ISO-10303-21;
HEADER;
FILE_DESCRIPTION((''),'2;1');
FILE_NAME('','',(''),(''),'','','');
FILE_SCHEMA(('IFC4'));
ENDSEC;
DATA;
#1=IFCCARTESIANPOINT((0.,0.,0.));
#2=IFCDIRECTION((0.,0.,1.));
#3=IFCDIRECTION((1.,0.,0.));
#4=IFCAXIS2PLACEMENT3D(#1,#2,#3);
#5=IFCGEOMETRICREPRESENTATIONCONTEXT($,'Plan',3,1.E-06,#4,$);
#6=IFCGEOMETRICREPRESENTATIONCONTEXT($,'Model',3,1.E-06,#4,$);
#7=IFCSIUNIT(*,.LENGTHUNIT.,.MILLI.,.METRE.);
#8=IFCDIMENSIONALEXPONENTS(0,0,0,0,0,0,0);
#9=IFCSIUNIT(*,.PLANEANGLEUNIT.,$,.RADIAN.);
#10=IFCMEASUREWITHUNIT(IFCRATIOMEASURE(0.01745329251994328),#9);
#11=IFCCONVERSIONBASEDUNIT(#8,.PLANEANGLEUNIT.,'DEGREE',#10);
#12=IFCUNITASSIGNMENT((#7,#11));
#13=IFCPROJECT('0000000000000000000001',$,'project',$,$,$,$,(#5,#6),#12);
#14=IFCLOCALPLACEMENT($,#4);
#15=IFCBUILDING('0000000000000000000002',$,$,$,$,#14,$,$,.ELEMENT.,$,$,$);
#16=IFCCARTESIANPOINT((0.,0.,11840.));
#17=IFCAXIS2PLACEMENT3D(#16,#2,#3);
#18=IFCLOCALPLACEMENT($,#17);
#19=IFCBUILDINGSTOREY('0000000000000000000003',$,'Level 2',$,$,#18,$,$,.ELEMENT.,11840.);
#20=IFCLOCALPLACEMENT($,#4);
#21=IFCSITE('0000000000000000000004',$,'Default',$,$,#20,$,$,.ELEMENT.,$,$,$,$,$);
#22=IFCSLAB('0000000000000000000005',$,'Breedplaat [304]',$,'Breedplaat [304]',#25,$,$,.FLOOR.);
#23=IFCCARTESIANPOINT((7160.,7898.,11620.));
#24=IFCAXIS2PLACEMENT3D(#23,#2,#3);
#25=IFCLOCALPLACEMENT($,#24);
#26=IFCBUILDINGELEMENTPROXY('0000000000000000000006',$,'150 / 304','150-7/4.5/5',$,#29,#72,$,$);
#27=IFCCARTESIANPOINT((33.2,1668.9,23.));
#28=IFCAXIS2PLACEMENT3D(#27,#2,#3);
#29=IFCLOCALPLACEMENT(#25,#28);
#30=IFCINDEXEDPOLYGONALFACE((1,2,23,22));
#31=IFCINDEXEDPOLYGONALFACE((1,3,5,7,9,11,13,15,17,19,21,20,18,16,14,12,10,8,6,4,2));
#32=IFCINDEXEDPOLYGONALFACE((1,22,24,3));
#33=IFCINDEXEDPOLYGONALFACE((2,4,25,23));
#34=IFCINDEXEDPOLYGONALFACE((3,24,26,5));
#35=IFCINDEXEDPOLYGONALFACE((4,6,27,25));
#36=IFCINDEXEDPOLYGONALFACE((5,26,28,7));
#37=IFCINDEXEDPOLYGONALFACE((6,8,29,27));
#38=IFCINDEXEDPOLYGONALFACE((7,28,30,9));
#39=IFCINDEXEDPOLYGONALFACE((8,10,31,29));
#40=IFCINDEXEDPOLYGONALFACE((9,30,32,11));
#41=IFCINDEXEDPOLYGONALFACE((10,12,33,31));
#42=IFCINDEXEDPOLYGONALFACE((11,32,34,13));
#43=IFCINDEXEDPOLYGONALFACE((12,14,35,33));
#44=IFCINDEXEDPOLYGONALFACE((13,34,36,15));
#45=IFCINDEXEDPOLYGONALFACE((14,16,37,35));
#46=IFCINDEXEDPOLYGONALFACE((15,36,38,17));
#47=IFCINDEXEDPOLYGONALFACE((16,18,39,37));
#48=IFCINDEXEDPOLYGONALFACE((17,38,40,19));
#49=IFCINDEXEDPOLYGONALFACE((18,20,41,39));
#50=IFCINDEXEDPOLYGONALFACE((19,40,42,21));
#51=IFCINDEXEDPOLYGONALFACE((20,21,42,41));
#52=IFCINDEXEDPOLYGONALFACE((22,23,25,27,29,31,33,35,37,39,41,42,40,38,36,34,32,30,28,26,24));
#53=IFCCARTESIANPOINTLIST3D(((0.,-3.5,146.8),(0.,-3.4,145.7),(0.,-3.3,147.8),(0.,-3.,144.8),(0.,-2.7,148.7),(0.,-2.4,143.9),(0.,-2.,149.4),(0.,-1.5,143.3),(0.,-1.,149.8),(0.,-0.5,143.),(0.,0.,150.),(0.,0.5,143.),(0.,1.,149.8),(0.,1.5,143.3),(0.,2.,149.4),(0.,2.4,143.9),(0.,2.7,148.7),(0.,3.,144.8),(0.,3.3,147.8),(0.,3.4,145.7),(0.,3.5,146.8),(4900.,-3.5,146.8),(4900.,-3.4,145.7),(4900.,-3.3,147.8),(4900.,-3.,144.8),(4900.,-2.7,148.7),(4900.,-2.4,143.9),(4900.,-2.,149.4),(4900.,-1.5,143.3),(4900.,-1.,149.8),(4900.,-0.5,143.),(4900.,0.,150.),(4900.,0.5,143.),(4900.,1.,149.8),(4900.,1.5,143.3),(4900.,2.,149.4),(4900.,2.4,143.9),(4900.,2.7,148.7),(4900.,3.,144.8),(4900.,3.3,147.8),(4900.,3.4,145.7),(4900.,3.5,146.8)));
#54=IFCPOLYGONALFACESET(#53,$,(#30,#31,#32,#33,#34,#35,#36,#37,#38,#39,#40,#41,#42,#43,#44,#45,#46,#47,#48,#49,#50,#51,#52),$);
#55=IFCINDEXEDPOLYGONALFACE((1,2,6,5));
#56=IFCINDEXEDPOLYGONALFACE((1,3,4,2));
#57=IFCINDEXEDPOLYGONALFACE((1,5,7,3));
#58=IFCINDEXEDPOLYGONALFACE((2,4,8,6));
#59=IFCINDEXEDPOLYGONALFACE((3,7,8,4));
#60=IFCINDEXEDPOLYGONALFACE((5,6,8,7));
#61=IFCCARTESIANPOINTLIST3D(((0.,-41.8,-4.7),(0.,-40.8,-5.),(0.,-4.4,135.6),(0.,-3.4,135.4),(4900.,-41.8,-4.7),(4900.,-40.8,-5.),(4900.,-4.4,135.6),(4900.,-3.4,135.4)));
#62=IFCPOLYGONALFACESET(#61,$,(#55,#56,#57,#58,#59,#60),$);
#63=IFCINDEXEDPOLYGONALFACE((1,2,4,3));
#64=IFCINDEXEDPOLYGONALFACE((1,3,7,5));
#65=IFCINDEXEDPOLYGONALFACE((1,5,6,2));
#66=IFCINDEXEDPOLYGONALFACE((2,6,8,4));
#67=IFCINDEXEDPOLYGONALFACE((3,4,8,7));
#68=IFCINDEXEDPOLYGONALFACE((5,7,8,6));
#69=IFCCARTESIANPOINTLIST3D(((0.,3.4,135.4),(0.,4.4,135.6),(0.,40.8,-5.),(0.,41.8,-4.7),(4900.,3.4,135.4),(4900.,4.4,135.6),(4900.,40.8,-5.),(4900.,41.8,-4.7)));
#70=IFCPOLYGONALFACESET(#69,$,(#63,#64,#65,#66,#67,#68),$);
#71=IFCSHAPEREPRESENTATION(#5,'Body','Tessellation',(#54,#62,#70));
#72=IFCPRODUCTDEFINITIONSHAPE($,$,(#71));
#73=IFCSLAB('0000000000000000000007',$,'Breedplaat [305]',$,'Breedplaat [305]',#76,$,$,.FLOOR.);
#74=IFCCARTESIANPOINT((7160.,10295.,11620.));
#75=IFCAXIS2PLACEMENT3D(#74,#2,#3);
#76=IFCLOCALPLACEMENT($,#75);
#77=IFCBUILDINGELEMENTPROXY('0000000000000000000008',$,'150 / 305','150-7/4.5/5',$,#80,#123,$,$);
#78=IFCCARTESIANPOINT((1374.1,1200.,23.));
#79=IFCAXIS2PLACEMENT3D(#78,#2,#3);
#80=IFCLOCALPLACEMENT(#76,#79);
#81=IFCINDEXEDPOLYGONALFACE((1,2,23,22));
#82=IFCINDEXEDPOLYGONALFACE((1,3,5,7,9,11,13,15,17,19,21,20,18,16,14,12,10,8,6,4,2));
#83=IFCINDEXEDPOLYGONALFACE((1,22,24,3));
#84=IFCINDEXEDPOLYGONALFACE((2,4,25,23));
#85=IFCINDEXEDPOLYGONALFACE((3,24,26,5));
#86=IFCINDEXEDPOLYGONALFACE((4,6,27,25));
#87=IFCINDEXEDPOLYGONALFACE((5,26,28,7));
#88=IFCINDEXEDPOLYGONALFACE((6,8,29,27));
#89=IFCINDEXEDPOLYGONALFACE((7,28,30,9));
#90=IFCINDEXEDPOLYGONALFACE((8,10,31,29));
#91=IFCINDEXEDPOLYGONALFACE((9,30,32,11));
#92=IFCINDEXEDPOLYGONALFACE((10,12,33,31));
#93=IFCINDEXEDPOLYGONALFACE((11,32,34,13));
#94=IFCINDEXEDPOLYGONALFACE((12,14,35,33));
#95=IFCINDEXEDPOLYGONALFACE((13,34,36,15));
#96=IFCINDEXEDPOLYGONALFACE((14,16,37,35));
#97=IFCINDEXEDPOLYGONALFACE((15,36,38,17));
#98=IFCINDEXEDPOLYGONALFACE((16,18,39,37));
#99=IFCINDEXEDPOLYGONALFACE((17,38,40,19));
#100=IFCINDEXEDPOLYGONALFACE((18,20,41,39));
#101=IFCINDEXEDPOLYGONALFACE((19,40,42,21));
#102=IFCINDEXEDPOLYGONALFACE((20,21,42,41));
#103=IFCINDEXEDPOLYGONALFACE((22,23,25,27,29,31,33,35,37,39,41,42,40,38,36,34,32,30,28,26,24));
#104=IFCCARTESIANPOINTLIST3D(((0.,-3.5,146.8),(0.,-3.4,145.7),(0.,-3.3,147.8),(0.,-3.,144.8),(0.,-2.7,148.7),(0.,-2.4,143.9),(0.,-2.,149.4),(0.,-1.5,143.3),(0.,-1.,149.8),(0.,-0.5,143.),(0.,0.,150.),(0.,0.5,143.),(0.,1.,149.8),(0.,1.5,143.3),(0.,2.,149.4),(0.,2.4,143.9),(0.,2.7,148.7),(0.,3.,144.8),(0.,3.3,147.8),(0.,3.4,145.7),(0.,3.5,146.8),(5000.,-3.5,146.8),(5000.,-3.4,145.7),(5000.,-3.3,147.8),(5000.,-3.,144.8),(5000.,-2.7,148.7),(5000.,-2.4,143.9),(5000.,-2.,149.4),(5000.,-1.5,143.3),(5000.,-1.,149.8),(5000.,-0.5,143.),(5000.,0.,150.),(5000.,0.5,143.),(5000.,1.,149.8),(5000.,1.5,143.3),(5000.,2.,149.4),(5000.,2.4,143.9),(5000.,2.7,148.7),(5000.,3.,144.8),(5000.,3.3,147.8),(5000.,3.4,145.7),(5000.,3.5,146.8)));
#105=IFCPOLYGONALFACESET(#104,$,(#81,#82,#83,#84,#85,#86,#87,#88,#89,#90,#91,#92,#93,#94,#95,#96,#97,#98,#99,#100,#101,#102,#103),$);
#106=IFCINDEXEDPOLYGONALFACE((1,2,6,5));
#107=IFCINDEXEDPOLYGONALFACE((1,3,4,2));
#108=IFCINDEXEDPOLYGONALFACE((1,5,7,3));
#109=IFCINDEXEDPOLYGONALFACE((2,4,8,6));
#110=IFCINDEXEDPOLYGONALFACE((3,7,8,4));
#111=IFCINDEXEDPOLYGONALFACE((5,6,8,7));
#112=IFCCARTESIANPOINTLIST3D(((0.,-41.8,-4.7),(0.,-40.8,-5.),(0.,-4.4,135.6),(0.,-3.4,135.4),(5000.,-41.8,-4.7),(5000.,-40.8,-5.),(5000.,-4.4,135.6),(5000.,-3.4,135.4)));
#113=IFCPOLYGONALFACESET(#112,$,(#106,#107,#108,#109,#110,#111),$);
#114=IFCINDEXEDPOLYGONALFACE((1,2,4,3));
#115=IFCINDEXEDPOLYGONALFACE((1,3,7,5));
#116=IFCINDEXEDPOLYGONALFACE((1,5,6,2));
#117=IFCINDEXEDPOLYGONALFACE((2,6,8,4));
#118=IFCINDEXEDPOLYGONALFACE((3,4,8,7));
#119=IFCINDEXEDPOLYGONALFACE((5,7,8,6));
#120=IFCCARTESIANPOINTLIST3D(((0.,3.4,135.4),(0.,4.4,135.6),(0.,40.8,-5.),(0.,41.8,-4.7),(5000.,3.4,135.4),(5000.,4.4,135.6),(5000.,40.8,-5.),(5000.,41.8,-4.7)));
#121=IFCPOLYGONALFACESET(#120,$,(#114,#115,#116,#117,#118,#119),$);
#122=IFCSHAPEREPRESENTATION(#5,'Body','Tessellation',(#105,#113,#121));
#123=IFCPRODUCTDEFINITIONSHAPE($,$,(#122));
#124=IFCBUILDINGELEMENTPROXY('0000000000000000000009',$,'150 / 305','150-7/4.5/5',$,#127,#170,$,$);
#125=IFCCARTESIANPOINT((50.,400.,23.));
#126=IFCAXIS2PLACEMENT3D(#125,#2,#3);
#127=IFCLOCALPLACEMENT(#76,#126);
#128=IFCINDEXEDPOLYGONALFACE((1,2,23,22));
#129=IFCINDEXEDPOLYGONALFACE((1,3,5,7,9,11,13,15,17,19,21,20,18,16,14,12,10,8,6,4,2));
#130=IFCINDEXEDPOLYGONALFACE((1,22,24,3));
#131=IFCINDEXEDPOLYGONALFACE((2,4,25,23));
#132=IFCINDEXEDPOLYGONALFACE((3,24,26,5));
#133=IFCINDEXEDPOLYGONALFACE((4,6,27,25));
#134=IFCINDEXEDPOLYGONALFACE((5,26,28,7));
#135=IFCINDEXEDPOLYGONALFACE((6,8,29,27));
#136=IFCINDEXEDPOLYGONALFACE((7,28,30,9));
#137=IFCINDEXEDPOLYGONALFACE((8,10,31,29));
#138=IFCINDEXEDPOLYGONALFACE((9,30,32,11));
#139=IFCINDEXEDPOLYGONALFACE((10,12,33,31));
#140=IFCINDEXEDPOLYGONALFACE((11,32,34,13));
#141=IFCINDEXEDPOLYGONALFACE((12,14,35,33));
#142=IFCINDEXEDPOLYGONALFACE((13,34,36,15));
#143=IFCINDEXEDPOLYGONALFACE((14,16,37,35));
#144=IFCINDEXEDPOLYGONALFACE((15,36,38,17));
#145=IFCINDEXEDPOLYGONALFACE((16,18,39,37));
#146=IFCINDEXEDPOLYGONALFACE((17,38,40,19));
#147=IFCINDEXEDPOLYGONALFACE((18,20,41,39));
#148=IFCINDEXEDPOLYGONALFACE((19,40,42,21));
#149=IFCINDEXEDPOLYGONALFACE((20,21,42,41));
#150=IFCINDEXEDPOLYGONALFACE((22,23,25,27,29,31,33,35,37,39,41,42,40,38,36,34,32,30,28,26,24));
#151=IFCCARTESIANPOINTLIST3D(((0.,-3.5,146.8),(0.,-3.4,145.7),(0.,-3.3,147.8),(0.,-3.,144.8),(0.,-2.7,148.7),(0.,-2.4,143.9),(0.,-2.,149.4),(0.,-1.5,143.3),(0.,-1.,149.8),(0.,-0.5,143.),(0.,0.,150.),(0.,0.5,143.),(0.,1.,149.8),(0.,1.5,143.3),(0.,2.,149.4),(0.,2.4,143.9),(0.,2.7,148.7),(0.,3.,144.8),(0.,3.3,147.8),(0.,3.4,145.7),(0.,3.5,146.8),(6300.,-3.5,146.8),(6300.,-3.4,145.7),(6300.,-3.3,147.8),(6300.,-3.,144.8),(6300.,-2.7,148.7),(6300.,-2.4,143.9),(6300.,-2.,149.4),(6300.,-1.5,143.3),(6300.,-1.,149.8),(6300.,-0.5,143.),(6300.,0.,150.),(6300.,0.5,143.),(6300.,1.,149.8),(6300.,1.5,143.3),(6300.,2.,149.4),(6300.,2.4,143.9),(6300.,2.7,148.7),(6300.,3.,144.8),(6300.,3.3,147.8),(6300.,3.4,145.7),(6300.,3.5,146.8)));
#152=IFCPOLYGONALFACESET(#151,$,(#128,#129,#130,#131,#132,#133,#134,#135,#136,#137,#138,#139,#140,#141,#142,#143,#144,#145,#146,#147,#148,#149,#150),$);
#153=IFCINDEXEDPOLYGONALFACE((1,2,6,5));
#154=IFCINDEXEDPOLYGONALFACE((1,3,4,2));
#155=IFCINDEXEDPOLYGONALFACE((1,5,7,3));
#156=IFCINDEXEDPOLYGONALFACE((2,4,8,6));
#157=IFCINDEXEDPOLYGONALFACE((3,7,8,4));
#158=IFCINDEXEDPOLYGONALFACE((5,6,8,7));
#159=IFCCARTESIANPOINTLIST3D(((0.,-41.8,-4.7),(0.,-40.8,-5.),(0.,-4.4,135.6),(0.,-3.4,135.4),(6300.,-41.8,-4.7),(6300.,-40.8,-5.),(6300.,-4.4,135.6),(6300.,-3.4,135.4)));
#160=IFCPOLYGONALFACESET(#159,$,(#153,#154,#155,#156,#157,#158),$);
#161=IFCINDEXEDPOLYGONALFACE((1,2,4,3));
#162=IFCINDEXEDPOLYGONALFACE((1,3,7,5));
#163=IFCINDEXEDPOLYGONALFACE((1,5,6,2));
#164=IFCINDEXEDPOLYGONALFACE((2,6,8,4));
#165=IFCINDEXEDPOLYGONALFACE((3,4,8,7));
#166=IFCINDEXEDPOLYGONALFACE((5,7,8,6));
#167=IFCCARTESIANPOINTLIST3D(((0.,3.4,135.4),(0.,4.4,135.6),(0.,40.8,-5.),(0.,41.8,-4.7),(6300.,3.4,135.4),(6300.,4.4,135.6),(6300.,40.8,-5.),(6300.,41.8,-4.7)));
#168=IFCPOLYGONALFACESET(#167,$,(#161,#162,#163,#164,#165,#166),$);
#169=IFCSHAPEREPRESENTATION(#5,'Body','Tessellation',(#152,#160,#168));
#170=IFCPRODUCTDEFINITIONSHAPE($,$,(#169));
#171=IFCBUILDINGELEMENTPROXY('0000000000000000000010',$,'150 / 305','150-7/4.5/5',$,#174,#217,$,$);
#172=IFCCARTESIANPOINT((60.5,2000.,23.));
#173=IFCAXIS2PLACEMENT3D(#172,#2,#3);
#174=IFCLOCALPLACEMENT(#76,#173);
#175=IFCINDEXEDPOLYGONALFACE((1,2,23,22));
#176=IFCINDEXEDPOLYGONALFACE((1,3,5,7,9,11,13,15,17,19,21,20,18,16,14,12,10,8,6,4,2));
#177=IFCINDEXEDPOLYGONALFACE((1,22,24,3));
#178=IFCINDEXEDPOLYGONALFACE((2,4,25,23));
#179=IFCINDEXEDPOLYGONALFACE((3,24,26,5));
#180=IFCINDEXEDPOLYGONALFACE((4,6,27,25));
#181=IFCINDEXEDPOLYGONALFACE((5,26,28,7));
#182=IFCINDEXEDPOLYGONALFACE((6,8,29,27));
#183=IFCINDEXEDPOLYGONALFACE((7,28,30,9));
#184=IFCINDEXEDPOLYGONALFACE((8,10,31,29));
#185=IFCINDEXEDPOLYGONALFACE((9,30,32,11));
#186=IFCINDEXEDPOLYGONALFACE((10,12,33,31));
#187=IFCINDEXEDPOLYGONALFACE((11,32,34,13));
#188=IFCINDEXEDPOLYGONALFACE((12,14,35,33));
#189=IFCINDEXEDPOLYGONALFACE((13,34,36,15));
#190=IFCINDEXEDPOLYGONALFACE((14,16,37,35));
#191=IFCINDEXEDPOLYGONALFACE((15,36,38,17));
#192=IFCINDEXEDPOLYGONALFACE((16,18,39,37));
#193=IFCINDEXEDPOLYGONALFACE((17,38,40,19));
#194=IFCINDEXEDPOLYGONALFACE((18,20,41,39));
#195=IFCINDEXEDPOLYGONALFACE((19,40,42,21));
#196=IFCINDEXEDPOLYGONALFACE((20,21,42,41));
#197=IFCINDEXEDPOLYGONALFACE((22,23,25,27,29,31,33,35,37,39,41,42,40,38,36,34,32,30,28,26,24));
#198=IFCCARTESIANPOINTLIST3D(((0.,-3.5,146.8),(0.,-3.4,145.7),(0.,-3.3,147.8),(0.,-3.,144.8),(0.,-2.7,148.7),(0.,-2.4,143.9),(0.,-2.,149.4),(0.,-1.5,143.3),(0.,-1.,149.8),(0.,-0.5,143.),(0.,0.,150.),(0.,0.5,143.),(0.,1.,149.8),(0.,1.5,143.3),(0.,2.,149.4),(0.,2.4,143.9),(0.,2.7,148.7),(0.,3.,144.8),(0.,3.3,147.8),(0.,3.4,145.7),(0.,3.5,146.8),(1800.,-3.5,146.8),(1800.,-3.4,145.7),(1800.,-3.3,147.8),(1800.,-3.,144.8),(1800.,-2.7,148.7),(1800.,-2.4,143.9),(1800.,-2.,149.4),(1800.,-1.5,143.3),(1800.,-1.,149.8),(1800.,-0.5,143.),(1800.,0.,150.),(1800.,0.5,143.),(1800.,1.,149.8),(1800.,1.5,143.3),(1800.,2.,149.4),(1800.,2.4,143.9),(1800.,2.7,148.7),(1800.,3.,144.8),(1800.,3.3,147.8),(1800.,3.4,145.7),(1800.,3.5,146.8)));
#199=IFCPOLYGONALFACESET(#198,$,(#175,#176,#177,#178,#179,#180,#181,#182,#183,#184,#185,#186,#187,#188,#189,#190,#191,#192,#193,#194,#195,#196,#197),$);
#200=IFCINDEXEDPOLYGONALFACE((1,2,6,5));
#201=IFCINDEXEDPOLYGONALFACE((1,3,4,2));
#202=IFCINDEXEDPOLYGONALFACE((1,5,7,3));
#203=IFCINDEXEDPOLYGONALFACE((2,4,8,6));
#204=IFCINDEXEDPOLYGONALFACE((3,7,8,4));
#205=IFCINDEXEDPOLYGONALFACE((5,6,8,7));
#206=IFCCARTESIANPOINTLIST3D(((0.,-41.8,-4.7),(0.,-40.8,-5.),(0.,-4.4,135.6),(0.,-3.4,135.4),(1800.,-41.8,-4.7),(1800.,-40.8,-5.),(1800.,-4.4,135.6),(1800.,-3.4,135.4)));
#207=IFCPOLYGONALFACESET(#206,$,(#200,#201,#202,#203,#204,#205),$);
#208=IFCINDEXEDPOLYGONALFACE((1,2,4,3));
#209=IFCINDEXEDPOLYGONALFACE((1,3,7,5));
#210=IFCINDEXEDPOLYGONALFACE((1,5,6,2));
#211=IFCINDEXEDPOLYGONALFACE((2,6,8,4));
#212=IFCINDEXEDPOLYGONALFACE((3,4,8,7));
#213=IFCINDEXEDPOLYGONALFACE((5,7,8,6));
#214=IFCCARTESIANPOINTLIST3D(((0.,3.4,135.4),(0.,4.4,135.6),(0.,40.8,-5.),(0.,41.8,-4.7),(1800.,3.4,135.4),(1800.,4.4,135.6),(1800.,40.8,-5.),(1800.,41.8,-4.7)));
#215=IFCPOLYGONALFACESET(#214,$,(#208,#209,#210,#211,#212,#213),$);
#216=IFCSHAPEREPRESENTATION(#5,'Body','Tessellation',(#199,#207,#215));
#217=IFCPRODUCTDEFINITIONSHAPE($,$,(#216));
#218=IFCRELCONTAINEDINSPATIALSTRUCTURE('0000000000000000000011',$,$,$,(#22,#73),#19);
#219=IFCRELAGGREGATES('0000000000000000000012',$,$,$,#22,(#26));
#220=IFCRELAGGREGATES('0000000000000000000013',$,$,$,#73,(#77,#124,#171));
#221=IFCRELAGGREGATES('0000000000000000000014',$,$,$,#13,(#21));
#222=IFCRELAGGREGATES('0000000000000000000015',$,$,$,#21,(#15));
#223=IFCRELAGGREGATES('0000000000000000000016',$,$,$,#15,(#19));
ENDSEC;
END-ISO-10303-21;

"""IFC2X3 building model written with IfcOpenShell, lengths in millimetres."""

from ifc_helpers import new_model, entity, si_unit, converted_unit, frame, origin_with_axes, origin_2d_with_axis, place, context, project, spatial, rectangle, circle, extrude, element, aggregate, save


model = new_model("IFC2X3")

# Units and contexts
plan_context = context("Plan", 3, precision=1e-06, world=origin_with_axes())
model_context = context("Model", 3, precision=1e-06, world=origin_with_axes())
ifc_project = project(units=[si_unit("LENGTHUNIT", "METRE", prefix="MILLI"), converted_unit("PLANEANGLEUNIT", "DEGREE", entity("IfcRatioMeasure", 0.01745329251994328), si_unit("PLANEANGLEUNIT", "RADIAN"), dimensions=[0, 0, 0, 0, 0, 0, 0])], contexts=[plan_context, model_context])

# Site, building, storey
site_placement = place(None, origin_with_axes())
site = spatial("IfcSite", under=ifc_project, at=site_placement, Name="Default", CompositionType="ELEMENT")
building_placement = place(None, origin_with_axes())
building = spatial("IfcBuilding", under=site, at=building_placement, CompositionType="ELEMENT")
storey_placement = place(None, frame((0.0, 0.0, 11840.0), z_axis=(0.0, 0.0, 1.0), x_axis=(1.0, 0.0, 0.0)))
storey = spatial("IfcBuildingStorey", under=building, at=storey_placement, Name="Level 2", CompositionType="ELEMENT", Elevation=11840.0)

# Slab, building element proxy
slab_1_placement = place(None, frame((7160.0, 7898.0, 11620.0), z_axis=(0.0, 0.0, 1.0), x_axis=(1.0, 0.0, 0.0)))
slab_1 = element("IfcSlab", 1, at=slab_1_placement, inside=storey, Name="Breedplaat [304]", ObjectType="Breedplaat [304]", PredefinedType="FLOOR")
proxy_1_placement = place(slab_1_placement, frame((33.2, 1668.9, 23.0), z_axis=(0.0, 0.0, 1.0), x_axis=(1.0, 0.0, 0.0)))
proxy_1 = element("IfcBuildingElementProxy", 2, at=proxy_1_placement, Name="150 / 304", Description="150-7/4.5/5", context=plan_context, shape_type="SweptSolid", body=[
    extrude(circle(Radius=3.5, at=origin_2d_with_axis()), frame((0.0, 0.0, 146.5), z_axis=(1.0, 0.0, 0.0), x_axis=(0.0, 0.0, 1.0)), (0.0, 0.0, 1.0), 4900.0),
    extrude(rectangle(XDim=145.2, YDim=1.0, at=origin_2d_with_axis()), frame((0.0, -22.6, 65.3), z_axis=(1.0, 0.0, 0.0), x_axis=(0.0, 0.257663, 0.966235)), (0.0, 0.0, 1.0), 4900.0),
    extrude(rectangle(XDim=145.2, YDim=1.0, at=origin_2d_with_axis()), frame((0.0, 22.6, 65.3), z_axis=(1.0, 0.0, 0.0), x_axis=(0.0, -0.257663, 0.966235)), (0.0, 0.0, 1.0), 4900.0),
])
aggregate(slab_1, [proxy_1])

# Slab, building element proxies
slab_2_placement = place(None, frame((7160.0, 10295.0, 11620.0), z_axis=(0.0, 0.0, 1.0), x_axis=(1.0, 0.0, 0.0)))
slab_2 = element("IfcSlab", 3, at=slab_2_placement, inside=storey, Name="Breedplaat [305]", ObjectType="Breedplaat [305]", PredefinedType="FLOOR")
proxy_2_placement = place(slab_2_placement, frame((1374.1, 1200.0, 23.0), z_axis=(0.0, 0.0, 1.0), x_axis=(1.0, 0.0, 0.0)))
proxy_2 = element("IfcBuildingElementProxy", 4, at=proxy_2_placement, Name="150 / 305", Description="150-7/4.5/5", context=plan_context, shape_type="SweptSolid", body=[
    extrude(circle(Radius=3.5, at=origin_2d_with_axis()), frame((0.0, 0.0, 146.5), z_axis=(1.0, 0.0, 0.0), x_axis=(0.0, 0.0, 1.0)), (0.0, 0.0, 1.0), 5000.0),
    extrude(rectangle(XDim=145.2, YDim=1.0, at=origin_2d_with_axis()), frame((0.0, -22.6, 65.3), z_axis=(1.0, 0.0, 0.0), x_axis=(0.0, 0.257663, 0.966235)), (0.0, 0.0, 1.0), 5000.0),
    extrude(rectangle(XDim=145.2, YDim=1.0, at=origin_2d_with_axis()), frame((0.0, 22.6, 65.3), z_axis=(1.0, 0.0, 0.0), x_axis=(0.0, -0.257663, 0.966235)), (0.0, 0.0, 1.0), 5000.0),
])
proxy_3_placement = place(slab_2_placement, frame((50.0, 400.0, 23.0), z_axis=(0.0, 0.0, 1.0), x_axis=(1.0, 0.0, 0.0)))
proxy_3 = element("IfcBuildingElementProxy", 5, at=proxy_3_placement, Name="150 / 305", Description="150-7/4.5/5", context=plan_context, shape_type="SweptSolid", body=[
    extrude(circle(Radius=3.5, at=origin_2d_with_axis()), frame((0.0, 0.0, 146.5), z_axis=(1.0, 0.0, 0.0), x_axis=(0.0, 0.0, 1.0)), (0.0, 0.0, 1.0), 6300.0),
    extrude(rectangle(XDim=145.2, YDim=1.0, at=origin_2d_with_axis()), frame((0.0, -22.6, 65.3), z_axis=(1.0, 0.0, 0.0), x_axis=(0.0, 0.257663, 0.966235)), (0.0, 0.0, 1.0), 6300.0),
    extrude(rectangle(XDim=145.2, YDim=1.0, at=origin_2d_with_axis()), frame((0.0, 22.6, 65.3), z_axis=(1.0, 0.0, 0.0), x_axis=(0.0, -0.257663, 0.966235)), (0.0, 0.0, 1.0), 6300.0),
])
proxy_4_placement = place(slab_2_placement, frame((60.5, 2000.0, 23.0), z_axis=(0.0, 0.0, 1.0), x_axis=(1.0, 0.0, 0.0)))
proxy_4 = element("IfcBuildingElementProxy", 6, at=proxy_4_placement, Name="150 / 305", Description="150-7/4.5/5", context=plan_context, shape_type="SweptSolid", body=[
    extrude(circle(Radius=3.5, at=origin_2d_with_axis()), frame((0.0, 0.0, 146.5), z_axis=(1.0, 0.0, 0.0), x_axis=(0.0, 0.0, 1.0)), (0.0, 0.0, 1.0), 1800.0),
    extrude(rectangle(XDim=145.2, YDim=1.0, at=origin_2d_with_axis()), frame((0.0, -22.6, 65.3), z_axis=(1.0, 0.0, 0.0), x_axis=(0.0, 0.257663, 0.966235)), (0.0, 0.0, 1.0), 1800.0),
    extrude(rectangle(XDim=145.2, YDim=1.0, at=origin_2d_with_axis()), frame((0.0, 22.6, 65.3), z_axis=(1.0, 0.0, 0.0), x_axis=(0.0, -0.257663, 0.966235)), (0.0, 0.0, 1.0), 1800.0),
])
aggregate(slab_2, [proxy_2, proxy_3, proxy_4])

save(model, "model.ifc")
